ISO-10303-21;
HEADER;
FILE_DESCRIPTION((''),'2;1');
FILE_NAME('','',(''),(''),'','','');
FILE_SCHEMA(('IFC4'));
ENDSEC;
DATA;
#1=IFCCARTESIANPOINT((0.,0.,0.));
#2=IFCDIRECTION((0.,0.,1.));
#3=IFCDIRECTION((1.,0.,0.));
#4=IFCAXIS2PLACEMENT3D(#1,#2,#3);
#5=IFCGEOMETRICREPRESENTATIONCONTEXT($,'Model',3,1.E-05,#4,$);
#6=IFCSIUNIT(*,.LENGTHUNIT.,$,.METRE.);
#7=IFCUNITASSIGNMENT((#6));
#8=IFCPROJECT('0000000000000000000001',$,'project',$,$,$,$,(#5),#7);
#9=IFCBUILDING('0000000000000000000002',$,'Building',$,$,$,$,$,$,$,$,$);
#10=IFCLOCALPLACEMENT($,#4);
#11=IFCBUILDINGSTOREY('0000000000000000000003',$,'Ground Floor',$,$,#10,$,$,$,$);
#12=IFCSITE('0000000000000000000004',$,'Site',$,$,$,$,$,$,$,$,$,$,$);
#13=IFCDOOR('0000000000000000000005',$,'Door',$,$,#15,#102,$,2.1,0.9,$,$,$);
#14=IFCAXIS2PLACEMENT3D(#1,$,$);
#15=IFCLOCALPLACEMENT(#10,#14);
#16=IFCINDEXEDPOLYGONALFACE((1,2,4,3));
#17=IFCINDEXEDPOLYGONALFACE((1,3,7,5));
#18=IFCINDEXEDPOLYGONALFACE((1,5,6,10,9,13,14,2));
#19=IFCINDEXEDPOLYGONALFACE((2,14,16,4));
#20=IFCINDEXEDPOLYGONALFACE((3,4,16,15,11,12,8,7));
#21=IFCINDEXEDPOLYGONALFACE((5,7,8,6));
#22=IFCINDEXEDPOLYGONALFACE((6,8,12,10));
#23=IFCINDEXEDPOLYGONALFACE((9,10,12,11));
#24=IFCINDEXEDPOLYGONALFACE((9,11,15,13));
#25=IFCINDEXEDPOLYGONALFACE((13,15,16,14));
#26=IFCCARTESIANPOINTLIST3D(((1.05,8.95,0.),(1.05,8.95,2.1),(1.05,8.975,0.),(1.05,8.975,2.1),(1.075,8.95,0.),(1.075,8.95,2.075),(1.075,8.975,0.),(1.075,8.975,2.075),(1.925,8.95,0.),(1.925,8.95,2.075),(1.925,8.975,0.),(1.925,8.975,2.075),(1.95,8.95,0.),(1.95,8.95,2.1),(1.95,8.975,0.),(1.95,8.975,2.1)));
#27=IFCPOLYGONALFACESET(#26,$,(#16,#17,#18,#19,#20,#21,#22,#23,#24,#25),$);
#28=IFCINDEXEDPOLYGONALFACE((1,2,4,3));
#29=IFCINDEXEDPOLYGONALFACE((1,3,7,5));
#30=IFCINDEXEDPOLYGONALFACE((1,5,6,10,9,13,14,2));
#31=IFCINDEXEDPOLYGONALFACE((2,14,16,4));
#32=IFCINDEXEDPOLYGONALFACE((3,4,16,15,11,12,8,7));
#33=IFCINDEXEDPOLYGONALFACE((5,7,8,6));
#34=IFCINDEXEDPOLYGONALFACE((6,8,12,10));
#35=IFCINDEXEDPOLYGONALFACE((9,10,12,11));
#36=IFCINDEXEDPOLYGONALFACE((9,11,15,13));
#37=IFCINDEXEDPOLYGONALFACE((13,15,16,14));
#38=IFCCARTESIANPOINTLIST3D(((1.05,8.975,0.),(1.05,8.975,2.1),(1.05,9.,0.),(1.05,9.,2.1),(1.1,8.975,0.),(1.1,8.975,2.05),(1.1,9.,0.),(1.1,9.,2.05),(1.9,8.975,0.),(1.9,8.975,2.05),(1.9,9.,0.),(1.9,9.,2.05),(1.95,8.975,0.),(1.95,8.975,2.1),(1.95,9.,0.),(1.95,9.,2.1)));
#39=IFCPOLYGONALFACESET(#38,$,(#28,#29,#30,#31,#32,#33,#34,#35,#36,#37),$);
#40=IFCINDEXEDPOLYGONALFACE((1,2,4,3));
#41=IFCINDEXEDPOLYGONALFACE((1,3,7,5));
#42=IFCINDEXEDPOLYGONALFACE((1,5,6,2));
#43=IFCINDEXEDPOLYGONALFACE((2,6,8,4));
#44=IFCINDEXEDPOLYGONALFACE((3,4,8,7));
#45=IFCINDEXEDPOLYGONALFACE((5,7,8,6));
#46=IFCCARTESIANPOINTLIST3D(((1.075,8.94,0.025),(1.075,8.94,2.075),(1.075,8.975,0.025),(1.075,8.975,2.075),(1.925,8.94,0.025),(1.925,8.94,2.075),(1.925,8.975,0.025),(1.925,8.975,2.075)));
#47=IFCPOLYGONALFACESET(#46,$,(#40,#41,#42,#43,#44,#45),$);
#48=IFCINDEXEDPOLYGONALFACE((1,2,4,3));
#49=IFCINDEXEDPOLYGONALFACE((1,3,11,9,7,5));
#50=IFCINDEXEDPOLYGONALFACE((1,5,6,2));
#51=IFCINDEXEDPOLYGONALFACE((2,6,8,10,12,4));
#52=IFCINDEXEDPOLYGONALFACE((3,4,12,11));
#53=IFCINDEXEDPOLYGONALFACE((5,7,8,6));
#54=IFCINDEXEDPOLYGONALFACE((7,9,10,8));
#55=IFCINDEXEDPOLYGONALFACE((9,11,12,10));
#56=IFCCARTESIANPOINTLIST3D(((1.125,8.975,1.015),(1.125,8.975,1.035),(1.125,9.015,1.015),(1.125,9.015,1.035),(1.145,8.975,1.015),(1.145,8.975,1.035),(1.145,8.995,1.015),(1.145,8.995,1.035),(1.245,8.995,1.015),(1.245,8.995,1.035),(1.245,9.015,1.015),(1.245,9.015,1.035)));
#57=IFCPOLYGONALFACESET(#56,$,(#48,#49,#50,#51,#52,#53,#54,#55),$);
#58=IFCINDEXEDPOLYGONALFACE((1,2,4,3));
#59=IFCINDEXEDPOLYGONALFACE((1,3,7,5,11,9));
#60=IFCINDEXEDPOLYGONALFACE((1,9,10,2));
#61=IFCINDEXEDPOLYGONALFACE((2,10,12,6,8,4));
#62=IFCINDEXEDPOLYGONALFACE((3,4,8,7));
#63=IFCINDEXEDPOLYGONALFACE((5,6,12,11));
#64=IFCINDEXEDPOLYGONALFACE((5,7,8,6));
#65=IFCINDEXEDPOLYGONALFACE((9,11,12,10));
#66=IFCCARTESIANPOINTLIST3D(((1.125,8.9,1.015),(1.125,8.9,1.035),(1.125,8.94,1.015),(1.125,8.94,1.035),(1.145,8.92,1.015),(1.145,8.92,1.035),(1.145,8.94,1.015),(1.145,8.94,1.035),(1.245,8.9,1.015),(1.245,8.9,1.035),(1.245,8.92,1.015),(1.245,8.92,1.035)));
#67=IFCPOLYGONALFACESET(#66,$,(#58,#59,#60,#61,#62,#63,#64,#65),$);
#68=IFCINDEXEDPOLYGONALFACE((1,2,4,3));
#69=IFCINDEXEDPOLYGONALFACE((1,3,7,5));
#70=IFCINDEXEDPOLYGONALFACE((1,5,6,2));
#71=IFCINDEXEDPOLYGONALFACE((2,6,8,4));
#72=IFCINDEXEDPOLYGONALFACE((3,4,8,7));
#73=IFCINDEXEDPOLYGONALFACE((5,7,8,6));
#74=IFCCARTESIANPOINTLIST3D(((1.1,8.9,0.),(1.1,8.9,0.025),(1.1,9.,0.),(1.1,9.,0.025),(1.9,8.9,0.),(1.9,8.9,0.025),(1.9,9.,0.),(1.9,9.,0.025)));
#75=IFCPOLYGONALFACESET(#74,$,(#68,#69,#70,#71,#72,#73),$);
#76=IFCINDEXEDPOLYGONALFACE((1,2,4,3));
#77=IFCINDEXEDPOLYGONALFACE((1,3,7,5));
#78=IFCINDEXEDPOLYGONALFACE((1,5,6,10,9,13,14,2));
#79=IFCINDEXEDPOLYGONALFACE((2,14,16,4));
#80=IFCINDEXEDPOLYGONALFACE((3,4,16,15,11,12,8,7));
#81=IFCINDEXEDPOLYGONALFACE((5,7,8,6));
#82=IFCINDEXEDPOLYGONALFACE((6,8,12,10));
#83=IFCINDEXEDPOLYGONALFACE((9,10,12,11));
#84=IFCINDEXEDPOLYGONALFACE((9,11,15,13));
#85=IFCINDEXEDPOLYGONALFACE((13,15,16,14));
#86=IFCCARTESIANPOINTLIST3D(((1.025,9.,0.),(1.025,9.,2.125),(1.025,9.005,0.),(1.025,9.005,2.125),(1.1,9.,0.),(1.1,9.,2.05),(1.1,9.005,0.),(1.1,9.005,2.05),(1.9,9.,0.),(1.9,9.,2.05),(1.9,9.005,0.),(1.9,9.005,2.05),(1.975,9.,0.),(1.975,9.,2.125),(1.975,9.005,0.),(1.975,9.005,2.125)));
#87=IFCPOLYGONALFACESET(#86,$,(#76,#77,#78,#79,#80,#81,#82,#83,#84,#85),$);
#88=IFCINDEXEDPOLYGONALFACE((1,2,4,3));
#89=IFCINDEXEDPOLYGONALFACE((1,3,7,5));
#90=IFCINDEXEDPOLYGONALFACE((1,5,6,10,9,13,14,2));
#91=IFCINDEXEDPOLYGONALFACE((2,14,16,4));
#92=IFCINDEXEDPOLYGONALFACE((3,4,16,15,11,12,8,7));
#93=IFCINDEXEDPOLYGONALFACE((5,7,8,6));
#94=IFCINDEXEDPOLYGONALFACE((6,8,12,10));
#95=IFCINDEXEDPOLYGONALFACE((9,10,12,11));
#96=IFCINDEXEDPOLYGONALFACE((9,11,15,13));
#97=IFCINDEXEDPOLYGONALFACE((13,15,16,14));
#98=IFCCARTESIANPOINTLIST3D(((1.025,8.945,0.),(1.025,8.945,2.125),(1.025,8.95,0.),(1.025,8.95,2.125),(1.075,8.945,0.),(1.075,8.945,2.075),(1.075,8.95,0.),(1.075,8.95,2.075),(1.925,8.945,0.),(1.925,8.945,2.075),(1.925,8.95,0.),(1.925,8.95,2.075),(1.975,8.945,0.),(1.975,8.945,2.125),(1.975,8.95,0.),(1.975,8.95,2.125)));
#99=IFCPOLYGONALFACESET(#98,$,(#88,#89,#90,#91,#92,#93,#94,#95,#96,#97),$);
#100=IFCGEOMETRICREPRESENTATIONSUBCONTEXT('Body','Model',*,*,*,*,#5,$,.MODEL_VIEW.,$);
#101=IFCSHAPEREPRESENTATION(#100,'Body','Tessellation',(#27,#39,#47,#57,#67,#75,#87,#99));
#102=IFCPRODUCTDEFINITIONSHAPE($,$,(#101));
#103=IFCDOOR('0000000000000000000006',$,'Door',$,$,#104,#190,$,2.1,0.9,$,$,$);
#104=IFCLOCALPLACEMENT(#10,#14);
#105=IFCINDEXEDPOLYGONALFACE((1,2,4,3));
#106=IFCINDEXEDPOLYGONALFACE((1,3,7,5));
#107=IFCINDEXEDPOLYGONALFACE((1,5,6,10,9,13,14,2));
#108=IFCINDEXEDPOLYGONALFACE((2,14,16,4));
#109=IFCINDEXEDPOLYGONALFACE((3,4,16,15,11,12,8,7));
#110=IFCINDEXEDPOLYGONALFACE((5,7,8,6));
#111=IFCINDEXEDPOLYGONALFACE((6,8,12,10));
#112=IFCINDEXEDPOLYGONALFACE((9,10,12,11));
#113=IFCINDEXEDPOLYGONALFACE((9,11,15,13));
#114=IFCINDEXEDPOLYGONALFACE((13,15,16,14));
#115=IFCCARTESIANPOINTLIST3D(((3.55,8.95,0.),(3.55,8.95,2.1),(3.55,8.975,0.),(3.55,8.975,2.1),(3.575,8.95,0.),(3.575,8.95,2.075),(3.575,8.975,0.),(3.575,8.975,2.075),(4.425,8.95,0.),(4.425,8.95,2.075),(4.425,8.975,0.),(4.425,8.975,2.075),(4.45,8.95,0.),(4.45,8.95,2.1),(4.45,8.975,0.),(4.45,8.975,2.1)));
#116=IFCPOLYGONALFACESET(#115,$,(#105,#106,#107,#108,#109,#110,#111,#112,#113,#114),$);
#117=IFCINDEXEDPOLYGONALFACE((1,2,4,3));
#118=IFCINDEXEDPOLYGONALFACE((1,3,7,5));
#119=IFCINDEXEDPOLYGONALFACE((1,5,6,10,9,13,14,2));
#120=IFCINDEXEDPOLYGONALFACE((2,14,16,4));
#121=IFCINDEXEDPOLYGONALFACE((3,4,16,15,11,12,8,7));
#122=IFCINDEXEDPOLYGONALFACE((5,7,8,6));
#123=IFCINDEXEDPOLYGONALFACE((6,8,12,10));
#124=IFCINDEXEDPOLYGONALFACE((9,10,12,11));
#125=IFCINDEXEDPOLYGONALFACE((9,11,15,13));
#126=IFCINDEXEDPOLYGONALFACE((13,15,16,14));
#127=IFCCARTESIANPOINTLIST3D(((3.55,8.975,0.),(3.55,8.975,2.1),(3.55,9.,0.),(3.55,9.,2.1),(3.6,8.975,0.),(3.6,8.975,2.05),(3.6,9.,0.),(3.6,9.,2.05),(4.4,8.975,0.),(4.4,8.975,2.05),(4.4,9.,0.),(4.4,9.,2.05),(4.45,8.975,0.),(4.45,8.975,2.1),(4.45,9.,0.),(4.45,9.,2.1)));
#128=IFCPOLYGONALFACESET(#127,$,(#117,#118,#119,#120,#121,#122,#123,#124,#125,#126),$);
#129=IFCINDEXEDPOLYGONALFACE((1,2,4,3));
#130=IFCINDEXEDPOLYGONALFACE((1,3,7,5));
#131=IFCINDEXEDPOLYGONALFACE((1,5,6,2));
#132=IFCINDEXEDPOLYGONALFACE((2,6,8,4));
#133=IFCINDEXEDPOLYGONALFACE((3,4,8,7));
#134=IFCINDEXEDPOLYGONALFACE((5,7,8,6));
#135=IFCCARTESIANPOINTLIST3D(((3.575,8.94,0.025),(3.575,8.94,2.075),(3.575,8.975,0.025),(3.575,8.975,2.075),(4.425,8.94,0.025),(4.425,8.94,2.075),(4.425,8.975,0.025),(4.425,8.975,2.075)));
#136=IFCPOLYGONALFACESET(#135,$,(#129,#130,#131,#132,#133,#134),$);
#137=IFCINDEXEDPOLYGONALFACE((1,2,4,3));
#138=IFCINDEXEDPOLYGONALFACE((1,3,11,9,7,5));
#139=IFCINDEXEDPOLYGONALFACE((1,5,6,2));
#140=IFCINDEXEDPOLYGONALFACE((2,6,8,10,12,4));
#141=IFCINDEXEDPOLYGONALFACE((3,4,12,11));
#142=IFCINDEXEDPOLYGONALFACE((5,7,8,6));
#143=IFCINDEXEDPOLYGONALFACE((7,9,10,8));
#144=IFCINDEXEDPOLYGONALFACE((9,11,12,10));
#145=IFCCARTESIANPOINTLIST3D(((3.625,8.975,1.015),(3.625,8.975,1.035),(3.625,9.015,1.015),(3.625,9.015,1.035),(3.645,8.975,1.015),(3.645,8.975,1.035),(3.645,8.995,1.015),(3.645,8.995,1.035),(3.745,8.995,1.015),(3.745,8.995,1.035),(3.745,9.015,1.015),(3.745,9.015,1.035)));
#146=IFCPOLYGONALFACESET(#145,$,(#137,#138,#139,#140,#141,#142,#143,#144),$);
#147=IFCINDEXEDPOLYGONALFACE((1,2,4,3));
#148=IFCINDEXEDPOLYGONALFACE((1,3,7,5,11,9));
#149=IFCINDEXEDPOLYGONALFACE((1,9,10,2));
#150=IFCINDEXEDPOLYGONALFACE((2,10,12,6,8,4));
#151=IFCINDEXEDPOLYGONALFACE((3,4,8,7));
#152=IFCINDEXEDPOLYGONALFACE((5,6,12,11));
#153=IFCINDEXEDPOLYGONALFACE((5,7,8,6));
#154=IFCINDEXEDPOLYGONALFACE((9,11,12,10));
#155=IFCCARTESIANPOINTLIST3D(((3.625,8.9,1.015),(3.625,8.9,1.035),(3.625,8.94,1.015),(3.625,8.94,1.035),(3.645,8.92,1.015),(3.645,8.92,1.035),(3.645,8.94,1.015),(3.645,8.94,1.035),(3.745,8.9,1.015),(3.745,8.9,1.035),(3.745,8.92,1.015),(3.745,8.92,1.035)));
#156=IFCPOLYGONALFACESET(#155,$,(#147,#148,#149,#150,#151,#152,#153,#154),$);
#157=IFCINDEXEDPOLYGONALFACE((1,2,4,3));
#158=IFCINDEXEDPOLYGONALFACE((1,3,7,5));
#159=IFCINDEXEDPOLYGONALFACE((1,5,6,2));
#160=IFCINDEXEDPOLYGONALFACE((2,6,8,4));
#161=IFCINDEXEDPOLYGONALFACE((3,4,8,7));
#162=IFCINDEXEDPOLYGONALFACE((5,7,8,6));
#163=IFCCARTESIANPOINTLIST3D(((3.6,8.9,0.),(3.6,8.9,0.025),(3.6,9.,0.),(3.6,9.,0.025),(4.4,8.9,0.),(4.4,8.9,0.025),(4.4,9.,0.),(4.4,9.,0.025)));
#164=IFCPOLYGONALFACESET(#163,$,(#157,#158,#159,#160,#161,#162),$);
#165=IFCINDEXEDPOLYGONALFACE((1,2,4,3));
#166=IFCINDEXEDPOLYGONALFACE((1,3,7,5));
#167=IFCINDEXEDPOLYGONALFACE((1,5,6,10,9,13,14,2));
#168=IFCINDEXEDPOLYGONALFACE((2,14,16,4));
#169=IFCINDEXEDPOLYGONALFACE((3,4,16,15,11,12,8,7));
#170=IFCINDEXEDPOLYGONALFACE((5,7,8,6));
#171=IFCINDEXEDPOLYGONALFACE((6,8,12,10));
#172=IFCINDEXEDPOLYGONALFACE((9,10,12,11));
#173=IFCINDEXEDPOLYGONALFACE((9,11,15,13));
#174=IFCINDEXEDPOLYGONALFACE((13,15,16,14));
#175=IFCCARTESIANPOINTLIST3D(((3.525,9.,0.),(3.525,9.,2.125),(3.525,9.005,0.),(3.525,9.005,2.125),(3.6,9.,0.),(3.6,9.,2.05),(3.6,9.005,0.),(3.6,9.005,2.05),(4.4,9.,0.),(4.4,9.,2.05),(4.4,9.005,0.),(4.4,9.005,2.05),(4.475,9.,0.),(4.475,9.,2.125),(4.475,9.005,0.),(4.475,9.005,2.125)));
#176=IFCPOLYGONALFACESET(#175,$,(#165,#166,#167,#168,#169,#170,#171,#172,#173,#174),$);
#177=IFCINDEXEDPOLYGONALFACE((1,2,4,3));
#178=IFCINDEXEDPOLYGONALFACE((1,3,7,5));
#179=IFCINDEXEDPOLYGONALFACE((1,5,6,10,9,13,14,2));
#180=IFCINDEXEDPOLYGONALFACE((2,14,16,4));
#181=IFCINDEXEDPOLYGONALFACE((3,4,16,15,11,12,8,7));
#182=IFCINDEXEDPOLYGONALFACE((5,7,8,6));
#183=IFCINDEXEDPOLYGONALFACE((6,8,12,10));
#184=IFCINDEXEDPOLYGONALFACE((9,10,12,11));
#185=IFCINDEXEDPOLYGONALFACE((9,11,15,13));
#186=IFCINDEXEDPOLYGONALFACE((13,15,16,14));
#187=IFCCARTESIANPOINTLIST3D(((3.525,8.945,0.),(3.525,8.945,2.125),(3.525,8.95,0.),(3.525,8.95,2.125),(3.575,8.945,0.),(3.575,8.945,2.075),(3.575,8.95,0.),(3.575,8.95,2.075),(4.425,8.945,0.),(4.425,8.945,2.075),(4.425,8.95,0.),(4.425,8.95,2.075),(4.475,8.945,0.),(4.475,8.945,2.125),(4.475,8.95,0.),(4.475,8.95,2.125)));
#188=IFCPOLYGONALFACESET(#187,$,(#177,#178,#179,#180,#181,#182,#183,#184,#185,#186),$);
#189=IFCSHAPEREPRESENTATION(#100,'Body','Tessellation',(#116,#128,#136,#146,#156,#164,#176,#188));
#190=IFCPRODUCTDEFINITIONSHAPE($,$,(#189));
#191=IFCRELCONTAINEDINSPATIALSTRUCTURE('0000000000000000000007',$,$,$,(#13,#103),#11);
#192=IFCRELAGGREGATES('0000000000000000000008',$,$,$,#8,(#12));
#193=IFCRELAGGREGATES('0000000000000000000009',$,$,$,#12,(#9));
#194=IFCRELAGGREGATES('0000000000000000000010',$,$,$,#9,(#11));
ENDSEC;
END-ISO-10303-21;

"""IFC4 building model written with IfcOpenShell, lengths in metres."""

from ifc_helpers import new_model, si_unit, frame, origin_with_axes, place, context, subcontext, project, spatial, line, indexed_curve, outline, extrude, element, save


model = new_model("IFC4")

# Units and contexts
model_context = context("Model", 3, precision=1e-05, world=origin_with_axes())
body_context = subcontext(model_context, "Body", "Model", "MODEL_VIEW")
ifc_project = project(units=[si_unit("LENGTHUNIT", "METRE")], contexts=[model_context])

# Site, building, storey
site = spatial("IfcSite", under=ifc_project, Name="Site")
building = spatial("IfcBuilding", under=site, Name="Building")
storey_placement = place(None, origin_with_axes())
storey = spatial("IfcBuildingStorey", under=building, at=storey_placement, Name="Ground Floor")

# Doors
door_1_placement = place(storey_placement, frame((1.95, 9.0, 0.0), z_axis=(0.0, 0.0, 1.0), x_axis=(-1.0, 0.0, 0.0)))
element("IfcDoor", 1, at=door_1_placement, inside=storey, Name="Door", OverallHeight=2.1, OverallWidth=0.9, context=body_context, shape_type="SweptSolid", body=[
    extrude(outline(indexed_curve([(0.0, 0.0), (0.0, 2.1), (0.9, 2.1), (0.9, 0.0), (0.875, 0.0), (0.875, 2.075), (0.025, 2.075), (0.025, 0.0)], segments=[line(1, 2, 3, 4, 5, 6, 7, 8, 1)])), frame((0.0, 0.025, 0.0), z_axis=(0.0, -1.0, 0.0), x_axis=(1.0, 0.0, 0.0)), (0.0, 0.0, -1.0), 0.025),
    extrude(outline(indexed_curve([(0.0, 0.0), (0.0, 2.1), (0.9, 2.1), (0.9, 0.0), (0.85, 0.0), (0.85, 2.05), (0.05, 2.05), (0.05, 0.0)], segments=[line(1, 2, 3, 4, 5, 6, 7, 8, 1)])), frame((0.0, 0.0, 0.0), z_axis=(0.0, -1.0, 0.0), x_axis=(1.0, 0.0, 0.0)), (0.0, 0.0, -1.0), 0.025),
    extrude(outline(indexed_curve([(0.0, 0.0), (0.85, 0.0), (0.85, 0.035), (0.0, 0.035)], segments=[line(1, 2, 3, 4, 1)])), frame((0.025, 0.025, 0.025), z_axis=(0.0, 0.0, 1.0), x_axis=(1.0, 0.0, 0.0)), (0.0, 0.0, 1.0), 2.05),
    extrude(outline(indexed_curve([(0.0, 0.0), (0.0, -0.04), (-0.12, -0.04), (-0.12, -0.02), (-0.02, -0.02), (-0.02, 0.0)], segments=[line(1, 2, 3, 4, 5, 6, 1)])), frame((0.825, 0.025, 1.015), z_axis=(0.0, 0.0, 1.0), x_axis=(1.0, 0.0, 0.0)), (0.0, 0.0, 1.0), 0.02),
    extrude(outline(indexed_curve([(0.0, 0.0), (0.0, 0.04), (-0.12, 0.04), (-0.12, 0.02), (-0.02, 0.02), (-0.02, 0.0)], segments=[line(1, 2, 3, 4, 5, 6, 1)])), frame((0.825, 0.06, 1.015), z_axis=(0.0, 0.0, 1.0), x_axis=(1.0, 0.0, 0.0)), (0.0, 0.0, 1.0), 0.02),
    extrude(outline(indexed_curve([(0.0, 0.0), (0.8, 0.0), (0.8, 0.1), (0.0, 0.1)], segments=[line(1, 2, 3, 4, 1)])), frame((0.05, 0.0, 0.0), z_axis=(0.0, 0.0, 1.0), x_axis=(1.0, 0.0, 0.0)), (0.0, 0.0, 1.0), 0.025),
    extrude(outline(indexed_curve([(0.0, 0.0), (0.0, 2.125), (0.95, 2.125), (0.95, 0.0), (0.875, 0.0), (0.875, 2.05), (0.075, 2.05), (0.075, 0.0)], segments=[line(1, 2, 3, 4, 5, 6, 7, 8, 1)])), frame((-0.025, -0.005, 0.0), z_axis=(0.0, -1.0, 0.0), x_axis=(1.0, 0.0, 0.0)), (0.0, 0.0, -1.0), 0.005),
    extrude(outline(indexed_curve([(0.0, 0.0), (0.0, 2.125), (0.95, 2.125), (0.95, 0.0), (0.9, 0.0), (0.9, 2.075), (0.05, 2.075), (0.05, 0.0)], segments=[line(1, 2, 3, 4, 5, 6, 7, 8, 1)])), frame((-0.025, 0.05, 0.0), z_axis=(0.0, -1.0, 0.0), x_axis=(1.0, 0.0, 0.0)), (0.0, 0.0, -1.0), 0.005),
])
door_2_placement = place(storey_placement, frame((4.45, 9.0, 0.0), z_axis=(0.0, 0.0, 1.0), x_axis=(-1.0, 0.0, 0.0)))
element("IfcDoor", 2, at=door_2_placement, inside=storey, Name="Door", OverallHeight=2.1, OverallWidth=0.9, context=body_context, shape_type="SweptSolid", body=[
    extrude(outline(indexed_curve([(0.0, 0.0), (0.0, 2.1), (0.9, 2.1), (0.9, 0.0), (0.875, 0.0), (0.875, 2.075), (0.025, 2.075), (0.025, 0.0)], segments=[line(1, 2, 3, 4, 5, 6, 7, 8, 1)])), frame((0.0, 0.025, 0.0), z_axis=(0.0, -1.0, 0.0), x_axis=(1.0, 0.0, 0.0)), (0.0, 0.0, -1.0), 0.025),
    extrude(outline(indexed_curve([(0.0, 0.0), (0.0, 2.1), (0.9, 2.1), (0.9, 0.0), (0.85, 0.0), (0.85, 2.05), (0.05, 2.05), (0.05, 0.0)], segments=[line(1, 2, 3, 4, 5, 6, 7, 8, 1)])), frame((0.0, 0.0, 0.0), z_axis=(0.0, -1.0, 0.0), x_axis=(1.0, 0.0, 0.0)), (0.0, 0.0, -1.0), 0.025),
    extrude(outline(indexed_curve([(0.0, 0.0), (0.85, 0.0), (0.85, 0.035), (0.0, 0.035)], segments=[line(1, 2, 3, 4, 1)])), frame((0.025, 0.025, 0.025), z_axis=(0.0, 0.0, 1.0), x_axis=(1.0, 0.0, 0.0)), (0.0, 0.0, 1.0), 2.05),
    extrude(outline(indexed_curve([(0.0, 0.0), (0.0, -0.04), (-0.12, -0.04), (-0.12, -0.02), (-0.02, -0.02), (-0.02, 0.0)], segments=[line(1, 2, 3, 4, 5, 6, 1)])), frame((0.825, 0.025, 1.015), z_axis=(0.0, 0.0, 1.0), x_axis=(1.0, 0.0, 0.0)), (0.0, 0.0, 1.0), 0.02),
    extrude(outline(indexed_curve([(0.0, 0.0), (0.0, 0.04), (-0.12, 0.04), (-0.12, 0.02), (-0.02, 0.02), (-0.02, 0.0)], segments=[line(1, 2, 3, 4, 5, 6, 1)])), frame((0.825, 0.06, 1.015), z_axis=(0.0, 0.0, 1.0), x_axis=(1.0, 0.0, 0.0)), (0.0, 0.0, 1.0), 0.02),
    extrude(outline(indexed_curve([(0.0, 0.0), (0.8, 0.0), (0.8, 0.1), (0.0, 0.1)], segments=[line(1, 2, 3, 4, 1)])), frame((0.05, 0.0, 0.0), z_axis=(0.0, 0.0, 1.0), x_axis=(1.0, 0.0, 0.0)), (0.0, 0.0, 1.0), 0.025),
    extrude(outline(indexed_curve([(0.0, 0.0), (0.0, 2.125), (0.95, 2.125), (0.95, 0.0), (0.875, 0.0), (0.875, 2.05), (0.075, 2.05), (0.075, 0.0)], segments=[line(1, 2, 3, 4, 5, 6, 7, 8, 1)])), frame((-0.025, -0.005, 0.0), z_axis=(0.0, -1.0, 0.0), x_axis=(1.0, 0.0, 0.0)), (0.0, 0.0, -1.0), 0.005),
    extrude(outline(indexed_curve([(0.0, 0.0), (0.0, 2.125), (0.95, 2.125), (0.95, 0.0), (0.9, 0.0), (0.9, 2.075), (0.05, 2.075), (0.05, 0.0)], segments=[line(1, 2, 3, 4, 5, 6, 7, 8, 1)])), frame((-0.025, 0.05, 0.0), z_axis=(0.0, -1.0, 0.0), x_axis=(1.0, 0.0, 0.0)), (0.0, 0.0, -1.0), 0.005),
])

save(model, "model.ifc")
